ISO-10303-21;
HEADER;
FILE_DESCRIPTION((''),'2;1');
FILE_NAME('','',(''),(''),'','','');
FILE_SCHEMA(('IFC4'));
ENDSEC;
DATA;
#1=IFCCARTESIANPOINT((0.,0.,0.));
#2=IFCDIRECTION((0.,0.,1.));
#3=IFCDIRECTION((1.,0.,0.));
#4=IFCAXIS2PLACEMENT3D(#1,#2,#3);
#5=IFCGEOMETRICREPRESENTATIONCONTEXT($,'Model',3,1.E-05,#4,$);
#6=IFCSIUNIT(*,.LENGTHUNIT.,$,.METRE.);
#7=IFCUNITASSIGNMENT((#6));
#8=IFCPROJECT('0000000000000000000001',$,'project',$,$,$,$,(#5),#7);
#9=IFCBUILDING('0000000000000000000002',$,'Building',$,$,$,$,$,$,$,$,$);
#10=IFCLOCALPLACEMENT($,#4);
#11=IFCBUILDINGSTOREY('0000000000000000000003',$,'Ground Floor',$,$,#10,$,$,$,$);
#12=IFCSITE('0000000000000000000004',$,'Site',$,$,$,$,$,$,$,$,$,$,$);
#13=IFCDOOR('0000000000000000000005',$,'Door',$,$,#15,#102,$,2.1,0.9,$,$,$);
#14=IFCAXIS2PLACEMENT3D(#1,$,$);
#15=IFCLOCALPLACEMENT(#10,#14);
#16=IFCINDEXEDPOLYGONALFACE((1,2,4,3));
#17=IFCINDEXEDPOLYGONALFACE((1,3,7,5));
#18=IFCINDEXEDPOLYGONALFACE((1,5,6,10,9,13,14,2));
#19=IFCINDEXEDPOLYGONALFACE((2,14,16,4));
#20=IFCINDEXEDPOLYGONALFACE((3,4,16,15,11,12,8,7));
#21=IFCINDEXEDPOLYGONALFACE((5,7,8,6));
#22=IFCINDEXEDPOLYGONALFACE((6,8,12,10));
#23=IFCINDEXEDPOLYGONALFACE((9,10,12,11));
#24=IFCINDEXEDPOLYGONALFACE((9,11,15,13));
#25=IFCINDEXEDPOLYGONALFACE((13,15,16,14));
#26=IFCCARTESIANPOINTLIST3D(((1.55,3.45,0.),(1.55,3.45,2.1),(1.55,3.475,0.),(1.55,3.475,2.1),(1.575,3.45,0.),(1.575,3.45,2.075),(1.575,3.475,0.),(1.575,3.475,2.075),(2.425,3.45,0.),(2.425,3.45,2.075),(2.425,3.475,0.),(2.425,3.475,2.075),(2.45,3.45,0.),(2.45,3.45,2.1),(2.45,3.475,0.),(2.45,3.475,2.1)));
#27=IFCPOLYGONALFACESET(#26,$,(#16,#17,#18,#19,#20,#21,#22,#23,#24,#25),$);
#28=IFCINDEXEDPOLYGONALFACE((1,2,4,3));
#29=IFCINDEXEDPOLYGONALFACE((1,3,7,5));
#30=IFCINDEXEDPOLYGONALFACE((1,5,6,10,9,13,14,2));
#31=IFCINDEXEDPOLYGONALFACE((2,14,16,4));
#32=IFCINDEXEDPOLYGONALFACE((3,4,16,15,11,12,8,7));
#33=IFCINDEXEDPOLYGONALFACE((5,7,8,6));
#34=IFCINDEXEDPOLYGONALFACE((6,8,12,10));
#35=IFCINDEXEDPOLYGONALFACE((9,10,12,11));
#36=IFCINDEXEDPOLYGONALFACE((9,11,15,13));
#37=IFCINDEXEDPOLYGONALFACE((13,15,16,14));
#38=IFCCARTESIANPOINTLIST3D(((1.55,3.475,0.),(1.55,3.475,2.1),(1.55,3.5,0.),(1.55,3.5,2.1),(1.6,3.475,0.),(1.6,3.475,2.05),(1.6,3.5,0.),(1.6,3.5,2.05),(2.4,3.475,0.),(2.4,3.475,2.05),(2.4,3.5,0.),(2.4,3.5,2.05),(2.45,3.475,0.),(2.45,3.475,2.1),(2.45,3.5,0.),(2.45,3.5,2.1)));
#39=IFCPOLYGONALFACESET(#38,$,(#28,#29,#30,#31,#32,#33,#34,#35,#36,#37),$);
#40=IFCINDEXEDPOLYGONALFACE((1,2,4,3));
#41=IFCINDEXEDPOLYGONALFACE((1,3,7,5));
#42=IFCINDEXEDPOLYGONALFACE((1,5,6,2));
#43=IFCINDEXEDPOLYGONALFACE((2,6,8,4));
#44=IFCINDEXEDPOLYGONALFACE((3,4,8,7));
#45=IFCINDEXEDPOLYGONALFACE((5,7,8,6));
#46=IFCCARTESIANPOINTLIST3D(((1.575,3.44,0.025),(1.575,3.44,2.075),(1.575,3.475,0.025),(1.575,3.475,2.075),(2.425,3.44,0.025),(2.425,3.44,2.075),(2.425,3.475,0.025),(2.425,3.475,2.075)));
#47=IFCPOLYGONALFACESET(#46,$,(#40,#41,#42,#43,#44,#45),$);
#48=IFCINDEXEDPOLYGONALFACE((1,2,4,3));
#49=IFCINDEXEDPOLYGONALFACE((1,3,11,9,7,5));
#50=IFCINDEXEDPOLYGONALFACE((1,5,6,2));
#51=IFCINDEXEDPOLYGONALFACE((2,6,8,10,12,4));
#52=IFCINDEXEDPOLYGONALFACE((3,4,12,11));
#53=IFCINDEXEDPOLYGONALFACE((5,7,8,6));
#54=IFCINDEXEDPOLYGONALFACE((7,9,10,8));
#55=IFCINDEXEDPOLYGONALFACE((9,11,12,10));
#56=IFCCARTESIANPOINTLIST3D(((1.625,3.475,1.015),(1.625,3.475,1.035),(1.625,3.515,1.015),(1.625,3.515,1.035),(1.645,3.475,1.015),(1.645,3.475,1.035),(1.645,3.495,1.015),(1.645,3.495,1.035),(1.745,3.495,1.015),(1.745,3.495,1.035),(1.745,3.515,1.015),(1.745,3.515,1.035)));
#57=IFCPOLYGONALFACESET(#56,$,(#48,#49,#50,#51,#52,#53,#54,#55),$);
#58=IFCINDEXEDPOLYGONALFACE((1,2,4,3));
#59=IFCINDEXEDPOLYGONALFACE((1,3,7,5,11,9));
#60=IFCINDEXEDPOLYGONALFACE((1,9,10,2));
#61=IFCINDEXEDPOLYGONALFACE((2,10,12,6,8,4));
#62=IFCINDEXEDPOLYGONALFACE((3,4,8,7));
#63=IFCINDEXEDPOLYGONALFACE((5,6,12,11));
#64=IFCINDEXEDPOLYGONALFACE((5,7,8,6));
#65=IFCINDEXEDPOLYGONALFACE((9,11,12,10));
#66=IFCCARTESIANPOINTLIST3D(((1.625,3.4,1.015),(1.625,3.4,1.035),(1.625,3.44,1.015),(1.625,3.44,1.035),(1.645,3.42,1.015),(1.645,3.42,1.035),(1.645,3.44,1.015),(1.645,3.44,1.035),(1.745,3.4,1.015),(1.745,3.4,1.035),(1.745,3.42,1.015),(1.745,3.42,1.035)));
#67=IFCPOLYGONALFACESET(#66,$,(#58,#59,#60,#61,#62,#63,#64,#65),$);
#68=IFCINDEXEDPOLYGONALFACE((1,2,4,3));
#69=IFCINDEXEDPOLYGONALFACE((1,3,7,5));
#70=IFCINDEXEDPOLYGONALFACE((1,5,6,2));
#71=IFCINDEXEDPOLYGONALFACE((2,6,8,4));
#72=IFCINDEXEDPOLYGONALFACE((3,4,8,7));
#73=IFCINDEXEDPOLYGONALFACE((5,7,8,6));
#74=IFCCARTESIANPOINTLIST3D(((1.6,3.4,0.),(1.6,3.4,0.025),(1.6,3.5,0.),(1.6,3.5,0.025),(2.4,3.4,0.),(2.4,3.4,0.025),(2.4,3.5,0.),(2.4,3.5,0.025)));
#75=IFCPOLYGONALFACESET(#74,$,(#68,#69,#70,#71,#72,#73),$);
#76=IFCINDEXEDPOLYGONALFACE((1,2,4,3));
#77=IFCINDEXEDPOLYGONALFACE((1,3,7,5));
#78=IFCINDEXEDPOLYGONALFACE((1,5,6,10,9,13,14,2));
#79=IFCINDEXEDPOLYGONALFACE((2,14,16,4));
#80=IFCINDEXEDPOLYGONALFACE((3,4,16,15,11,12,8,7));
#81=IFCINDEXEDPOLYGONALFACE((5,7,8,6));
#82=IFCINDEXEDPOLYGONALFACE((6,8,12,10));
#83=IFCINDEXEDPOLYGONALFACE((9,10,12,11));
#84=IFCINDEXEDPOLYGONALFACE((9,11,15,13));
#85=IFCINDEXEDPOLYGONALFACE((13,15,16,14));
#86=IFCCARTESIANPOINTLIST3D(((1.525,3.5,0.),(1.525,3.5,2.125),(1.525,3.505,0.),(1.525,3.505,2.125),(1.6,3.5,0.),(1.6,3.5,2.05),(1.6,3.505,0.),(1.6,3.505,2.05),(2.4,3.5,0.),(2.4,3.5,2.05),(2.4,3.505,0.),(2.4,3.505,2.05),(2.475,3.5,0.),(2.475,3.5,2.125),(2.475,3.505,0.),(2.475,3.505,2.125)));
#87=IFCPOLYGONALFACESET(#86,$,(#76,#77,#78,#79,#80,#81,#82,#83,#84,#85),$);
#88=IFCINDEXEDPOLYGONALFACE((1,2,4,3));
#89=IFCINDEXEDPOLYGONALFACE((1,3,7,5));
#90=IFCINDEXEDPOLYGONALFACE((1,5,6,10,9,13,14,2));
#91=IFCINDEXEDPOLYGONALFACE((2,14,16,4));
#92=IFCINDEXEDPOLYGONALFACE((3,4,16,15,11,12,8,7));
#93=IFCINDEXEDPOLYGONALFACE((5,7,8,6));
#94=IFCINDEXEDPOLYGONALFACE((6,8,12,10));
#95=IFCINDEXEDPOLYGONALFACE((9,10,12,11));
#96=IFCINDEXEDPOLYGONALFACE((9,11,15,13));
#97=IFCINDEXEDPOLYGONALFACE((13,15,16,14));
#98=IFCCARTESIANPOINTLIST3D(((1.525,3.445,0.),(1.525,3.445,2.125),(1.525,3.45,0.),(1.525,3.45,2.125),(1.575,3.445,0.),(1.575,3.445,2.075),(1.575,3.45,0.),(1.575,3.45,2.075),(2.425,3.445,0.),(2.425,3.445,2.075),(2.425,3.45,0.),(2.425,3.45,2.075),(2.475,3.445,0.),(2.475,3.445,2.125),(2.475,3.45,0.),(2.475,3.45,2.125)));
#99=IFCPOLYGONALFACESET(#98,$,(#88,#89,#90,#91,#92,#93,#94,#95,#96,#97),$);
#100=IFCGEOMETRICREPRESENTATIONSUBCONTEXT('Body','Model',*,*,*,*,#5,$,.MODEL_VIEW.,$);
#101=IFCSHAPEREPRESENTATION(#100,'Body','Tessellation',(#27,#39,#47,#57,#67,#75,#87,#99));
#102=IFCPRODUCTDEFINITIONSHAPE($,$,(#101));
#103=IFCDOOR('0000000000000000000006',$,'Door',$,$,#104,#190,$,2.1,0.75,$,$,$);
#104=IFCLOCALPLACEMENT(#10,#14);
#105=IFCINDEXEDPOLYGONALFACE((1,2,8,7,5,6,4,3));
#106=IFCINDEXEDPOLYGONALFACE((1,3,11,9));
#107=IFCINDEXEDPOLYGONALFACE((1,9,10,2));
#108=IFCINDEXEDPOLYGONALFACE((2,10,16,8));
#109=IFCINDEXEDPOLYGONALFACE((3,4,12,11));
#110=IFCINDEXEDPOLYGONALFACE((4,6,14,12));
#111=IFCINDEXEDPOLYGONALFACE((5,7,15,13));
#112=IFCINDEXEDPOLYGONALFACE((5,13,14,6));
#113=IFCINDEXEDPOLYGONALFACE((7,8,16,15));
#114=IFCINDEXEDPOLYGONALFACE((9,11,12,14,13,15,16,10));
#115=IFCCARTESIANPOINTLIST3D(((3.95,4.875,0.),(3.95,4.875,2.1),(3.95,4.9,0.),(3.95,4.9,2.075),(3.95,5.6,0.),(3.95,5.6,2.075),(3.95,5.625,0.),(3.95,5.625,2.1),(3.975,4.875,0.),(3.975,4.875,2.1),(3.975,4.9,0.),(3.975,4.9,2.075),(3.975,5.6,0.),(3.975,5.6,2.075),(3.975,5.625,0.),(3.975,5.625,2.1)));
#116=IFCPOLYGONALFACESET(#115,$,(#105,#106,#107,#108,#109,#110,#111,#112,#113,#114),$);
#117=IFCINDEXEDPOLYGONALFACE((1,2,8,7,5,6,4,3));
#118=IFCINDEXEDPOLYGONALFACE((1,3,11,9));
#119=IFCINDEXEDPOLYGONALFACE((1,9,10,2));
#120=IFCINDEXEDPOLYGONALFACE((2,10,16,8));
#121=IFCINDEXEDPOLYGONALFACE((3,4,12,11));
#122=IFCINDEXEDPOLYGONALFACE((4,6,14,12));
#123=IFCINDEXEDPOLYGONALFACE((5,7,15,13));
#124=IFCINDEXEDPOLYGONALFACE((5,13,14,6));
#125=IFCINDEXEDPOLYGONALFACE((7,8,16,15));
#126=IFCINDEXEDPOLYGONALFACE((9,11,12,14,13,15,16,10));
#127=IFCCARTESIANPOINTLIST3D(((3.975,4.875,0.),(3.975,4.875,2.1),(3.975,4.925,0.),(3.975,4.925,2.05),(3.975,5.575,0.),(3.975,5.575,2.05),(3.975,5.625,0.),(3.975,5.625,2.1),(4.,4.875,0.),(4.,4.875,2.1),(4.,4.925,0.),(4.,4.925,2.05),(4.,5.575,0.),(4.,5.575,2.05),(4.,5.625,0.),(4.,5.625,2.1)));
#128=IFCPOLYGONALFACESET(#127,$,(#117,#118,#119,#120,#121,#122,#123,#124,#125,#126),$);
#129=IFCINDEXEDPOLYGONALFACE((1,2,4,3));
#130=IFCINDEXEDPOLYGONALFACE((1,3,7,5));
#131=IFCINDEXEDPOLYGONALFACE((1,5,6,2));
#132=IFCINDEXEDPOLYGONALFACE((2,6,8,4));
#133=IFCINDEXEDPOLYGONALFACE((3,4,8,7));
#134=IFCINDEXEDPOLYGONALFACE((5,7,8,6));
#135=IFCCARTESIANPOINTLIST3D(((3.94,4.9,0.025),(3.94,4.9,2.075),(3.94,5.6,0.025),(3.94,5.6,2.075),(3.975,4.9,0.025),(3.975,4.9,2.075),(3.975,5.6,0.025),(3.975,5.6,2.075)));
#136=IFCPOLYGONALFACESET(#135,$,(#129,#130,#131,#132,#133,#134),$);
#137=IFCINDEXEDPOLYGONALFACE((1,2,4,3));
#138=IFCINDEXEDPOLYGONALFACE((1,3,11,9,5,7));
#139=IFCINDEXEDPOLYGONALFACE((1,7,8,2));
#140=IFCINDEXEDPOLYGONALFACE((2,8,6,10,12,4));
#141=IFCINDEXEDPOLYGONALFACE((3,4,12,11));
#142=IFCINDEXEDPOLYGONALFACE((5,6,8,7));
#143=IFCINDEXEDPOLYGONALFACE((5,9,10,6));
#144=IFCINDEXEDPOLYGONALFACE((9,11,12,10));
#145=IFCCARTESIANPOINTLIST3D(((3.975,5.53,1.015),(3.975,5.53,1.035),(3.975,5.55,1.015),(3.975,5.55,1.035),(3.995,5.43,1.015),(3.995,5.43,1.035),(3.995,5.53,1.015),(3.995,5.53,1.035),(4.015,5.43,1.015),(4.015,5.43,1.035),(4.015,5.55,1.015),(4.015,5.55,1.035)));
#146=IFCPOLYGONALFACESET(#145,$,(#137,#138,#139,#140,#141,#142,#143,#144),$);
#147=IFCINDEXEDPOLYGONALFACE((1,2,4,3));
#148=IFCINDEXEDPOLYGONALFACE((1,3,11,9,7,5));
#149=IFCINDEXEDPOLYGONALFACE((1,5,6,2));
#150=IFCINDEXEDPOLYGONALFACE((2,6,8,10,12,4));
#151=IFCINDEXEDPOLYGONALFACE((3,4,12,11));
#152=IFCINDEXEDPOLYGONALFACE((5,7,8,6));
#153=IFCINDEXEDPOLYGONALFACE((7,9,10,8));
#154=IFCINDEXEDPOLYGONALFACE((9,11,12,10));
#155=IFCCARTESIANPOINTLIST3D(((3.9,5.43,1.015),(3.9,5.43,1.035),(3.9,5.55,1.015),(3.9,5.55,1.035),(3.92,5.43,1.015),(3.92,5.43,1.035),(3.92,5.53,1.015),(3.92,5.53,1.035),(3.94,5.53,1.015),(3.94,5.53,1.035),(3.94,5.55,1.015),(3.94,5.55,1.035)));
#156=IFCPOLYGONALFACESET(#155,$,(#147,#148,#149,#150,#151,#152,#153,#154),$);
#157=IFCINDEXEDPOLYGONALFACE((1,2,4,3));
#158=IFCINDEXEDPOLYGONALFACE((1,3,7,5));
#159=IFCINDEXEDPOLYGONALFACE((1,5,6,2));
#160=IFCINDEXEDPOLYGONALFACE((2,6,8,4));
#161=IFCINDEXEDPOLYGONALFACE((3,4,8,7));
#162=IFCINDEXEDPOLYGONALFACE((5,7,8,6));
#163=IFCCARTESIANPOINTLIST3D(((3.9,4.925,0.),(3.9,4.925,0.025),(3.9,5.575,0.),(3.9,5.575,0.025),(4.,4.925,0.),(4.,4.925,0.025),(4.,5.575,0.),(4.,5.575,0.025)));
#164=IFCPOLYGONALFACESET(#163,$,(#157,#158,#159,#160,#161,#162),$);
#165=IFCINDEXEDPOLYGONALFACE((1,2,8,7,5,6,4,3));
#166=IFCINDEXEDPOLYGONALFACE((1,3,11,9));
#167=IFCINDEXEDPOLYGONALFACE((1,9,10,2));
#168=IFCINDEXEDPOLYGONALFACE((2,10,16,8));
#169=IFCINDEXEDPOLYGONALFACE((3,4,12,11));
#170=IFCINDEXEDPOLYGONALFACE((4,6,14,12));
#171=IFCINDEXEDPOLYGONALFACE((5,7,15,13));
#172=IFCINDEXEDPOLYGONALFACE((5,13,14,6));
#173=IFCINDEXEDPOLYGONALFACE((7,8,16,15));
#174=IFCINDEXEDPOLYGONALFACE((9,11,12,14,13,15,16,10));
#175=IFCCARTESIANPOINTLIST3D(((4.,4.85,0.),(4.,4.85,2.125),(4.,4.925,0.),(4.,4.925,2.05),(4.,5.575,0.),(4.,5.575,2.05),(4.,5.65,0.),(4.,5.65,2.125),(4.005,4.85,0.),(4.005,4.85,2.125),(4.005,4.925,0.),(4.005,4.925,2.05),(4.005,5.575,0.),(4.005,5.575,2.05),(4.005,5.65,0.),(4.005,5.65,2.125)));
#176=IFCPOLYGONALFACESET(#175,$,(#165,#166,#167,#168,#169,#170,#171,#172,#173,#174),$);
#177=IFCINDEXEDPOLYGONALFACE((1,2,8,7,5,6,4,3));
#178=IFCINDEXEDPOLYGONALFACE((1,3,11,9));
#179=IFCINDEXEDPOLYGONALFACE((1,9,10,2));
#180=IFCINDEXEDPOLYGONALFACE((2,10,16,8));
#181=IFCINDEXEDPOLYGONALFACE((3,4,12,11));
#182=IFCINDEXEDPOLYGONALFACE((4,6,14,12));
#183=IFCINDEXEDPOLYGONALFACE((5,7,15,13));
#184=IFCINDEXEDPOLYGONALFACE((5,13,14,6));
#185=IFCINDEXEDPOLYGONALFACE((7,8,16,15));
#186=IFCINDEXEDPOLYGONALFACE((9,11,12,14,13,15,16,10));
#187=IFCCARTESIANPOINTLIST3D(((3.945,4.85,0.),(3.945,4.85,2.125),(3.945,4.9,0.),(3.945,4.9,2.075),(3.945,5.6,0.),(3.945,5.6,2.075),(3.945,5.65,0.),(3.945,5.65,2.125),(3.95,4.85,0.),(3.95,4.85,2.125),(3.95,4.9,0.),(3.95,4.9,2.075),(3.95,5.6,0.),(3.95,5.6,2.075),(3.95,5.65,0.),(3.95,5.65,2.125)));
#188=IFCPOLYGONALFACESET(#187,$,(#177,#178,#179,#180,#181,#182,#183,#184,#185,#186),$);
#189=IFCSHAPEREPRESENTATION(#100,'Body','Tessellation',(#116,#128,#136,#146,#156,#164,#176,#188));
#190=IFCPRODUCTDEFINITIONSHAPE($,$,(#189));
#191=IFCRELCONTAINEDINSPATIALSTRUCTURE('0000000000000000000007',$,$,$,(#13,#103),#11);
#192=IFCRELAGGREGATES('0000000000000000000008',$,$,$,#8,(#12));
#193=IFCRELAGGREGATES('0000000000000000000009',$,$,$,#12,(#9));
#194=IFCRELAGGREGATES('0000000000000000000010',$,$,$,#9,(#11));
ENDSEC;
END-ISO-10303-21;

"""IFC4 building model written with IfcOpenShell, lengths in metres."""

from ifc_helpers import new_model, si_unit, frame, origin_with_axes, place, context, subcontext, project, spatial, line, indexed_curve, outline, extrude, element, save


model = new_model("IFC4")

# Units and contexts
model_context = context("Model", 3, precision=1e-05, world=origin_with_axes())
body_context = subcontext(model_context, "Body", "Model", "MODEL_VIEW")
ifc_project = project(units=[si_unit("LENGTHUNIT", "METRE")], contexts=[model_context])

# Site, building, storey
site = spatial("IfcSite", under=ifc_project, Name="Site")
building = spatial("IfcBuilding", under=site, Name="Building")
storey_placement = place(None, origin_with_axes())
storey = spatial("IfcBuildingStorey", under=building, at=storey_placement, Name="Ground Floor")

# Doors
door_1_placement = place(storey_placement, frame((2.45, 3.5, 0.0), z_axis=(0.0, 0.0, 1.0), x_axis=(-1.0, 0.0, 0.0)))
element("IfcDoor", 1, at=door_1_placement, inside=storey, Name="Door", OverallHeight=2.1, OverallWidth=0.9, context=body_context, shape_type="SweptSolid", body=[
    extrude(outline(indexed_curve([(0.0, 0.0), (0.0, 2.1), (0.9, 2.1), (0.9, 0.0), (0.875, 0.0), (0.875, 2.075), (0.025, 2.075), (0.025, 0.0)], segments=[line(1, 2, 3, 4, 5, 6, 7, 8, 1)])), frame((0.0, 0.025, 0.0), z_axis=(0.0, -1.0, 0.0), x_axis=(1.0, 0.0, 0.0)), (0.0, 0.0, -1.0), 0.025),
    extrude(outline(indexed_curve([(0.0, 0.0), (0.0, 2.1), (0.9, 2.1), (0.9, 0.0), (0.85, 0.0), (0.85, 2.05), (0.05, 2.05), (0.05, 0.0)], segments=[line(1, 2, 3, 4, 5, 6, 7, 8, 1)])), frame((0.0, 0.0, 0.0), z_axis=(0.0, -1.0, 0.0), x_axis=(1.0, 0.0, 0.0)), (0.0, 0.0, -1.0), 0.025),
    extrude(outline(indexed_curve([(0.0, 0.0), (0.85, 0.0), (0.85, 0.035), (0.0, 0.035)], segments=[line(1, 2, 3, 4, 1)])), frame((0.025, 0.025, 0.025), z_axis=(0.0, 0.0, 1.0), x_axis=(1.0, 0.0, 0.0)), (0.0, 0.0, 1.0), 2.05),
    extrude(outline(indexed_curve([(0.0, 0.0), (0.0, -0.04), (-0.12, -0.04), (-0.12, -0.02), (-0.02, -0.02), (-0.02, 0.0)], segments=[line(1, 2, 3, 4, 5, 6, 1)])), frame((0.825, 0.025, 1.015), z_axis=(0.0, 0.0, 1.0), x_axis=(1.0, 0.0, 0.0)), (0.0, 0.0, 1.0), 0.02),
    extrude(outline(indexed_curve([(0.0, 0.0), (0.0, 0.04), (-0.12, 0.04), (-0.12, 0.02), (-0.02, 0.02), (-0.02, 0.0)], segments=[line(1, 2, 3, 4, 5, 6, 1)])), frame((0.825, 0.06, 1.015), z_axis=(0.0, 0.0, 1.0), x_axis=(1.0, 0.0, 0.0)), (0.0, 0.0, 1.0), 0.02),
    extrude(outline(indexed_curve([(0.0, 0.0), (0.8, 0.0), (0.8, 0.1), (0.0, 0.1)], segments=[line(1, 2, 3, 4, 1)])), frame((0.05, 0.0, 0.0), z_axis=(0.0, 0.0, 1.0), x_axis=(1.0, 0.0, 0.0)), (0.0, 0.0, 1.0), 0.025),
    extrude(outline(indexed_curve([(0.0, 0.0), (0.0, 2.125), (0.95, 2.125), (0.95, 0.0), (0.875, 0.0), (0.875, 2.05), (0.075, 2.05), (0.075, 0.0)], segments=[line(1, 2, 3, 4, 5, 6, 7, 8, 1)])), frame((-0.025, -0.005, 0.0), z_axis=(0.0, -1.0, 0.0), x_axis=(1.0, 0.0, 0.0)), (0.0, 0.0, -1.0), 0.005),
    extrude(outline(indexed_curve([(0.0, 0.0), (0.0, 2.125), (0.95, 2.125), (0.95, 0.0), (0.9, 0.0), (0.9, 2.075), (0.05, 2.075), (0.05, 0.0)], segments=[line(1, 2, 3, 4, 5, 6, 7, 8, 1)])), frame((-0.025, 0.05, 0.0), z_axis=(0.0, -1.0, 0.0), x_axis=(1.0, 0.0, 0.0)), (0.0, 0.0, -1.0), 0.005),
])
door_2_placement = place(storey_placement, frame((4.0, 4.875, 0.0), z_axis=(0.0, 0.0, 1.0), x_axis=(0.0, 1.0, 0.0)))
element("IfcDoor", 2, at=door_2_placement, inside=storey, Name="Door", OverallHeight=2.1, OverallWidth=0.75, context=body_context, shape_type="SweptSolid", body=[
    extrude(outline(indexed_curve([(0.0, 0.0), (0.0, 2.1), (0.75, 2.1), (0.75, 0.0), (0.725, 0.0), (0.725, 2.075), (0.025, 2.075), (0.025, 0.0)], segments=[line(1, 2, 3, 4, 5, 6, 7, 8, 1)])), frame((0.0, 0.025, 0.0), z_axis=(0.0, -1.0, 0.0), x_axis=(1.0, 0.0, 0.0)), (0.0, 0.0, -1.0), 0.025),
    extrude(outline(indexed_curve([(0.0, 0.0), (0.0, 2.1), (0.75, 2.1), (0.75, 0.0), (0.7, 0.0), (0.7, 2.05), (0.05, 2.05), (0.05, 0.0)], segments=[line(1, 2, 3, 4, 5, 6, 7, 8, 1)])), frame((0.0, 0.0, 0.0), z_axis=(0.0, -1.0, 0.0), x_axis=(1.0, 0.0, 0.0)), (0.0, 0.0, -1.0), 0.025),
    extrude(outline(indexed_curve([(0.0, 0.0), (0.7, 0.0), (0.7, 0.035), (0.0, 0.035)], segments=[line(1, 2, 3, 4, 1)])), frame((0.025, 0.025, 0.025), z_axis=(0.0, 0.0, 1.0), x_axis=(1.0, 0.0, 0.0)), (0.0, 0.0, 1.0), 2.05),
    extrude(outline(indexed_curve([(0.0, 0.0), (0.0, -0.04), (-0.12, -0.04), (-0.12, -0.02), (-0.02, -0.02), (-0.02, 0.0)], segments=[line(1, 2, 3, 4, 5, 6, 1)])), frame((0.675, 0.025, 1.015), z_axis=(0.0, 0.0, 1.0), x_axis=(1.0, 0.0, 0.0)), (0.0, 0.0, 1.0), 0.02),
    extrude(outline(indexed_curve([(0.0, 0.0), (0.0, 0.04), (-0.12, 0.04), (-0.12, 0.02), (-0.02, 0.02), (-0.02, 0.0)], segments=[line(1, 2, 3, 4, 5, 6, 1)])), frame((0.675, 0.06, 1.015), z_axis=(0.0, 0.0, 1.0), x_axis=(1.0, 0.0, 0.0)), (0.0, 0.0, 1.0), 0.02),
    extrude(outline(indexed_curve([(0.0, 0.0), (0.65, 0.0), (0.65, 0.1), (0.0, 0.1)], segments=[line(1, 2, 3, 4, 1)])), frame((0.05, 0.0, 0.0), z_axis=(0.0, 0.0, 1.0), x_axis=(1.0, 0.0, 0.0)), (0.0, 0.0, 1.0), 0.025),
    extrude(outline(indexed_curve([(0.0, 0.0), (0.0, 2.125), (0.8, 2.125), (0.8, 0.0), (0.725, 0.0), (0.725, 2.05), (0.075, 2.05), (0.075, 0.0)], segments=[line(1, 2, 3, 4, 5, 6, 7, 8, 1)])), frame((-0.025, -0.005, 0.0), z_axis=(0.0, -1.0, 0.0), x_axis=(1.0, 0.0, 0.0)), (0.0, 0.0, -1.0), 0.005),
    extrude(outline(indexed_curve([(0.0, 0.0), (0.0, 2.125), (0.8, 2.125), (0.8, 0.0), (0.75, 0.0), (0.75, 2.075), (0.05, 2.075), (0.05, 0.0)], segments=[line(1, 2, 3, 4, 5, 6, 7, 8, 1)])), frame((-0.025, 0.05, 0.0), z_axis=(0.0, -1.0, 0.0), x_axis=(1.0, 0.0, 0.0)), (0.0, 0.0, -1.0), 0.005),
])

save(model, "model.ifc")
